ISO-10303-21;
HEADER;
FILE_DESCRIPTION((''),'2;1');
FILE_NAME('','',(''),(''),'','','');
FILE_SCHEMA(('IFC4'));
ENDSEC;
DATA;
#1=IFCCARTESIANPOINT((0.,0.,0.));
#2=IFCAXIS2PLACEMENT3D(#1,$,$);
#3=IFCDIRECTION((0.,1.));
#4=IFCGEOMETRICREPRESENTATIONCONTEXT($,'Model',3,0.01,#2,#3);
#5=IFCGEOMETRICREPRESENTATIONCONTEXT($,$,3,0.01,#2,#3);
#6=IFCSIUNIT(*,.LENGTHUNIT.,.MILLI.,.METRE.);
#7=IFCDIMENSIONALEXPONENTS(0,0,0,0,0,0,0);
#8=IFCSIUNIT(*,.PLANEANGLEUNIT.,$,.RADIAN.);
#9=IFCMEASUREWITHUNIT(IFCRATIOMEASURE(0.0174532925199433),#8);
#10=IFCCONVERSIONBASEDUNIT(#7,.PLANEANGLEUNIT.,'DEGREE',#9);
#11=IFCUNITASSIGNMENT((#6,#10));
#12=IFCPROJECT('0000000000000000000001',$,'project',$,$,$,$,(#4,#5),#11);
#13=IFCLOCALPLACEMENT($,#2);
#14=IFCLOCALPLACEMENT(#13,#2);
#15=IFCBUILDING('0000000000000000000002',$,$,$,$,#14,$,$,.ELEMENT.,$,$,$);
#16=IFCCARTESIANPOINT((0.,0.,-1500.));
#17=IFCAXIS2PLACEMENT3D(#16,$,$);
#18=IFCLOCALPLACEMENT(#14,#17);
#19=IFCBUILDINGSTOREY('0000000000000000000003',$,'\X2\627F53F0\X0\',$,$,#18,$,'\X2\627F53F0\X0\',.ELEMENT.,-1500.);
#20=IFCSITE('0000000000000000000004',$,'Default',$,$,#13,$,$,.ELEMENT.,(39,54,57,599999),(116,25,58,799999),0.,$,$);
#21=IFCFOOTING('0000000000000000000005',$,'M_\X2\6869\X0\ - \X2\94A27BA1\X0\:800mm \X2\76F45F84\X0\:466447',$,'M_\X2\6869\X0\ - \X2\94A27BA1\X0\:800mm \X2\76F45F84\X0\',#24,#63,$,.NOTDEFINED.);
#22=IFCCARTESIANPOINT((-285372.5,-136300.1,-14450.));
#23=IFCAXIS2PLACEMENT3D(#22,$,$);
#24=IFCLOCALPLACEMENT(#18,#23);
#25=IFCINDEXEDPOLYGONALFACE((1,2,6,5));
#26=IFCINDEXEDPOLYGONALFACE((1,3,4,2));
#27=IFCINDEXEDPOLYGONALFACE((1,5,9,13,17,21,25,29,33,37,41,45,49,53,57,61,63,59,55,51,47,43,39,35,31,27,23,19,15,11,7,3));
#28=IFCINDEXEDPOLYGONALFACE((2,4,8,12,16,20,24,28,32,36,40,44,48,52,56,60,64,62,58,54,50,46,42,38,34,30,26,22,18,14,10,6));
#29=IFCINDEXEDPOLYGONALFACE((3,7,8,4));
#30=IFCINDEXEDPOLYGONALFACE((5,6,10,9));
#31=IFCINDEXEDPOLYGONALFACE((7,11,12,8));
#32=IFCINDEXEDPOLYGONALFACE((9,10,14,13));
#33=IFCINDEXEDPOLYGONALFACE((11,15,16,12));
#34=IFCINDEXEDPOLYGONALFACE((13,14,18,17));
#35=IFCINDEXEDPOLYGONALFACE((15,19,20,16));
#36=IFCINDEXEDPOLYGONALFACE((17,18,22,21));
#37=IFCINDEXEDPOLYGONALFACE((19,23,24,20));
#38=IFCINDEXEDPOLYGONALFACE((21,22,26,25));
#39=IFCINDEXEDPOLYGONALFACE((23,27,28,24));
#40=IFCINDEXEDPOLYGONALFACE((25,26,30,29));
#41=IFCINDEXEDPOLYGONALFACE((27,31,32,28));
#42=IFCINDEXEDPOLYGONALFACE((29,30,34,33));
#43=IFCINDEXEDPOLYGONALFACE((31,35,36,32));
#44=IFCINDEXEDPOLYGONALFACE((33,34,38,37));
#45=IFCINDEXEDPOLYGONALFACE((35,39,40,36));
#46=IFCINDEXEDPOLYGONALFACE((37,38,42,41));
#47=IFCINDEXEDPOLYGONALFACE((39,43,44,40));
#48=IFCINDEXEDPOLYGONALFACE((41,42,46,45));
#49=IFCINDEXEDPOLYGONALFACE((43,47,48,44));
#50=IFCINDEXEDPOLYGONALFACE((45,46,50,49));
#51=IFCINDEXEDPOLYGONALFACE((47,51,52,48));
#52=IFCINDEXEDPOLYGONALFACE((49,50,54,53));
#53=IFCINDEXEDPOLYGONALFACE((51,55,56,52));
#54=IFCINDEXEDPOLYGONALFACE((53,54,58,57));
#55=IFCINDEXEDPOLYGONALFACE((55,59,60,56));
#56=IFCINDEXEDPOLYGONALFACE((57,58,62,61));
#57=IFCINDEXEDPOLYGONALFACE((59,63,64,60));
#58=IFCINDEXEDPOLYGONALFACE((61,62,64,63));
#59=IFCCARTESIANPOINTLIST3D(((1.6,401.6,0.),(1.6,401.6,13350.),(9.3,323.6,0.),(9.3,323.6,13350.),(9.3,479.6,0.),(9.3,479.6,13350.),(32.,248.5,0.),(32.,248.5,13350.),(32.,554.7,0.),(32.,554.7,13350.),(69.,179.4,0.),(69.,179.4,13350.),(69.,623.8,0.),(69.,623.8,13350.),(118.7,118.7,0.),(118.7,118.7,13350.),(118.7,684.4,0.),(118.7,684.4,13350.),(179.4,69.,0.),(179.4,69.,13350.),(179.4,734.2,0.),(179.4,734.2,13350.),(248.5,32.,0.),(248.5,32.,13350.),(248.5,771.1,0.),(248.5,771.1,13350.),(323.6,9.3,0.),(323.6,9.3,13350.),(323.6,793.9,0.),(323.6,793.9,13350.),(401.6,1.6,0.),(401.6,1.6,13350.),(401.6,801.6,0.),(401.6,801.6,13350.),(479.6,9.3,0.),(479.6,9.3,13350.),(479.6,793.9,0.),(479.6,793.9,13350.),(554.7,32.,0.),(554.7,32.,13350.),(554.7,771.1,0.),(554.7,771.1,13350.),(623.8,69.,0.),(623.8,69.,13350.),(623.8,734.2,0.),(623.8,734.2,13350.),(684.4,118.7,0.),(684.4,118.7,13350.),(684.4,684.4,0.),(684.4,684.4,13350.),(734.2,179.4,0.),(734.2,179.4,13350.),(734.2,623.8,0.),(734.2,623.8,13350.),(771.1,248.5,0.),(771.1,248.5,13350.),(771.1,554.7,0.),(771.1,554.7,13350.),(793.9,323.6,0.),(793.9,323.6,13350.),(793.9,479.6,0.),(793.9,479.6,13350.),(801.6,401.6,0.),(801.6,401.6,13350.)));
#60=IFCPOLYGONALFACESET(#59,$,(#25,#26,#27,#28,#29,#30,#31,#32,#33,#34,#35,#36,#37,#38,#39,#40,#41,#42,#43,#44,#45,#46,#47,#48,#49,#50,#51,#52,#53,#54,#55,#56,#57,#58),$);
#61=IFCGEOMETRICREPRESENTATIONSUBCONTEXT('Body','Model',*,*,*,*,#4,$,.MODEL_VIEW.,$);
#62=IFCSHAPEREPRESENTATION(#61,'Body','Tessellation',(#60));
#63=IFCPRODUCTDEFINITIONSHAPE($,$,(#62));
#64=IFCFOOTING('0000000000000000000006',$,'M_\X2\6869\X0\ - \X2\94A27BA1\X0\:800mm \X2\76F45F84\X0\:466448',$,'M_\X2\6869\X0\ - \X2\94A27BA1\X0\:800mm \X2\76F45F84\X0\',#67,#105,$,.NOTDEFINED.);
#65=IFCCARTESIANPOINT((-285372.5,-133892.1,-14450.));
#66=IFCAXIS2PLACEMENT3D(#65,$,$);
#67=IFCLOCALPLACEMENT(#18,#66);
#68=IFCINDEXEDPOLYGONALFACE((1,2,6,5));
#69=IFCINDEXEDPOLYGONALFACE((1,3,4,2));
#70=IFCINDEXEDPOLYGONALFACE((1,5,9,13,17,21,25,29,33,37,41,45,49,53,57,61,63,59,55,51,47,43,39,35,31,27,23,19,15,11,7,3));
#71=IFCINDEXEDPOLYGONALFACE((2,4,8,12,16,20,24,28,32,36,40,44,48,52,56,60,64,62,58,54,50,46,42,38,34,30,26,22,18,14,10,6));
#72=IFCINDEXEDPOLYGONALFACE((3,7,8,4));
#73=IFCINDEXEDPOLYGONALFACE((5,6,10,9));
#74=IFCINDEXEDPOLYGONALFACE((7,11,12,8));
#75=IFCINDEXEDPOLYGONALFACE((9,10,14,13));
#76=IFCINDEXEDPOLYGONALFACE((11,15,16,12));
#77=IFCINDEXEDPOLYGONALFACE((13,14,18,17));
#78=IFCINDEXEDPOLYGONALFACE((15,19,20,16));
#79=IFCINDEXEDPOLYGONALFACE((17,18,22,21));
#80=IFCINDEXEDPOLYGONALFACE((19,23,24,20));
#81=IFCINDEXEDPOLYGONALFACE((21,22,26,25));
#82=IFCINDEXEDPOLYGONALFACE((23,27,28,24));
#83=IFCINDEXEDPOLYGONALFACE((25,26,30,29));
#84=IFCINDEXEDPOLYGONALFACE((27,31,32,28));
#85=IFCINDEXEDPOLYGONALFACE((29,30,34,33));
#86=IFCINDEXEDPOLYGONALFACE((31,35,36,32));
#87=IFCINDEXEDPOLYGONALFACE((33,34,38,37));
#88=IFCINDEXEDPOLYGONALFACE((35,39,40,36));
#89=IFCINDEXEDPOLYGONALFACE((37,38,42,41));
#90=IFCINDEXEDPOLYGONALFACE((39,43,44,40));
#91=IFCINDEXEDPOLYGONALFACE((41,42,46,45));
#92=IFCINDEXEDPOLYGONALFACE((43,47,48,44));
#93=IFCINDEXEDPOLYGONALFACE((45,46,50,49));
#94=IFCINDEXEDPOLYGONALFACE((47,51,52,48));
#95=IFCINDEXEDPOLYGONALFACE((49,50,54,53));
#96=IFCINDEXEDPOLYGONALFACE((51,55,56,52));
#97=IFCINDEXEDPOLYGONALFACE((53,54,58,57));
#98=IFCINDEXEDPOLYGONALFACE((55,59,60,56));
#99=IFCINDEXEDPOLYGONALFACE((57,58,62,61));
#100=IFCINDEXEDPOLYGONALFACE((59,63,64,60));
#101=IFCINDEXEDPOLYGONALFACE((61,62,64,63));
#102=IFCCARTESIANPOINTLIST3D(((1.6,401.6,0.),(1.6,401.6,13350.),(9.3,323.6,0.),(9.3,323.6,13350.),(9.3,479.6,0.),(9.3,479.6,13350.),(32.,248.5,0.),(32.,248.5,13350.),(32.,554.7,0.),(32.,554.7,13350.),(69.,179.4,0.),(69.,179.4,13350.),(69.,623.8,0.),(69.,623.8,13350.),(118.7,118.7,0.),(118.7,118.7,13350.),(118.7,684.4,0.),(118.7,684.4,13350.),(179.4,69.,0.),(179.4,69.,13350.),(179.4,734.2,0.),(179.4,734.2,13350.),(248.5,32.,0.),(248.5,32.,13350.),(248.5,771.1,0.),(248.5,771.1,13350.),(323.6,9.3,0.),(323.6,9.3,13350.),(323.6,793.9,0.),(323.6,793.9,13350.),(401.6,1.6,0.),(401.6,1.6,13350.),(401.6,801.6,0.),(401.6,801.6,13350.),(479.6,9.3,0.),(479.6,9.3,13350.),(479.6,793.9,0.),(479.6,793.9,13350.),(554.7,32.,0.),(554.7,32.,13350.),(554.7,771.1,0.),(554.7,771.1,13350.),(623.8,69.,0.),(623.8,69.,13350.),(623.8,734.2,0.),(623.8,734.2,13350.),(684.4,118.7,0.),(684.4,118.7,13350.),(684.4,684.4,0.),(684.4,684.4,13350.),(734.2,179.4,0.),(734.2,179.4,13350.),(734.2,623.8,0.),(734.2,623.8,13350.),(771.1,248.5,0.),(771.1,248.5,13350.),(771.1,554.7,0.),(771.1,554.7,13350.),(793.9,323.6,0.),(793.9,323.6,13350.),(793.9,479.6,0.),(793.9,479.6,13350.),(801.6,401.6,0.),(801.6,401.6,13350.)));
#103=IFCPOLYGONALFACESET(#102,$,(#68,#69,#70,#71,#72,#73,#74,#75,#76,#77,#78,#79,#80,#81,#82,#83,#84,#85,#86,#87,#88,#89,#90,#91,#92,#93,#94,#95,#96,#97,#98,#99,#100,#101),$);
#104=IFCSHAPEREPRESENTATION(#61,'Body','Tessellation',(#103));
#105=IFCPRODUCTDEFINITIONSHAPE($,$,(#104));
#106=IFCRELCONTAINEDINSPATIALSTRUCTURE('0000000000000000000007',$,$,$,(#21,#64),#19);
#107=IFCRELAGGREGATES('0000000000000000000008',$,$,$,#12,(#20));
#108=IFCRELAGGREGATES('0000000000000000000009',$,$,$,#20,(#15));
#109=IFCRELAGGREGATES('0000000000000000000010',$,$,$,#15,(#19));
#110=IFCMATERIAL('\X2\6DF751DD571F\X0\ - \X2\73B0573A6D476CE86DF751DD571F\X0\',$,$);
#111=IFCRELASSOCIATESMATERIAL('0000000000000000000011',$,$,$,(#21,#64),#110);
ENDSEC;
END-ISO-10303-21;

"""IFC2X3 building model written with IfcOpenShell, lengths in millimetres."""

from ifc_helpers import new_model, entity, si_unit, converted_unit, direction, frame, origin, origin_2d_with_axis, place, context, subcontext, project, spatial, circle, extrude, material, element, save


model = new_model("IFC2X3")

# Units and contexts
model_context = context("Model", 3, precision=0.01, world=origin(), true_north=direction((0.0, 1.0)))
context_of_model = context(None, 3, precision=0.01, world=origin(), true_north=direction((0.0, 1.0)))
body_context = subcontext(model_context, "Body", "Model", "MODEL_VIEW")
ifc_project = project(units=[si_unit("LENGTHUNIT", "METRE", prefix="MILLI"), converted_unit("PLANEANGLEUNIT", "DEGREE", entity("IfcRatioMeasure", 0.0174532925199433), si_unit("PLANEANGLEUNIT", "RADIAN"), dimensions=[0, 0, 0, 0, 0, 0, 0])], contexts=[model_context, context_of_model])

# Site, building, storey
site_placement = place(None, origin())
site = spatial("IfcSite", under=ifc_project, at=site_placement, Name="Default", CompositionType="ELEMENT", RefLatitude=(39, 54, 57, 599999), RefLongitude=(116, 25, 58, 799999), RefElevation=0.0)
building_placement = place(site_placement, origin())
building = spatial("IfcBuilding", under=site, at=building_placement, CompositionType="ELEMENT")
storey_placement = place(building_placement, frame((0.0, 0.0, -1500.0)))
storey = spatial("IfcBuildingStorey", under=building, at=storey_placement, Name="承台", LongName="承台", CompositionType="ELEMENT", Elevation=-1500.0)

# Footings
ifc_material_1 = material(Name="混凝土 - 现场浇注混凝土")
for number, where, name in (
    (1, (-285372.5, -136300.1, -14450.0), "M_桩 - 钢管:800mm 直径:466447"),
    (2, (-285372.5, -133892.1, -14450.0), "M_桩 - 钢管:800mm 直径:466448"),
):
    element("IfcFooting", number, at=place(storey_placement, frame(where)), inside=storey, material=ifc_material_1, Name=name, ObjectType="M_桩 - 钢管:800mm 直径", PredefinedType="NOTDEFINED", context=body_context, shape_type="SweptSolid", body=[
        extrude(circle(Radius=400.0, at=origin_2d_with_axis()), frame((401.6, 401.6, 0.0), z_axis=(0.0, 0.0, 1.0), x_axis=(0.0, 1.0, 0.0)), (0.0, 0.0, 1.0), 13350.0),
    ])

save(model, "model.ifc")
